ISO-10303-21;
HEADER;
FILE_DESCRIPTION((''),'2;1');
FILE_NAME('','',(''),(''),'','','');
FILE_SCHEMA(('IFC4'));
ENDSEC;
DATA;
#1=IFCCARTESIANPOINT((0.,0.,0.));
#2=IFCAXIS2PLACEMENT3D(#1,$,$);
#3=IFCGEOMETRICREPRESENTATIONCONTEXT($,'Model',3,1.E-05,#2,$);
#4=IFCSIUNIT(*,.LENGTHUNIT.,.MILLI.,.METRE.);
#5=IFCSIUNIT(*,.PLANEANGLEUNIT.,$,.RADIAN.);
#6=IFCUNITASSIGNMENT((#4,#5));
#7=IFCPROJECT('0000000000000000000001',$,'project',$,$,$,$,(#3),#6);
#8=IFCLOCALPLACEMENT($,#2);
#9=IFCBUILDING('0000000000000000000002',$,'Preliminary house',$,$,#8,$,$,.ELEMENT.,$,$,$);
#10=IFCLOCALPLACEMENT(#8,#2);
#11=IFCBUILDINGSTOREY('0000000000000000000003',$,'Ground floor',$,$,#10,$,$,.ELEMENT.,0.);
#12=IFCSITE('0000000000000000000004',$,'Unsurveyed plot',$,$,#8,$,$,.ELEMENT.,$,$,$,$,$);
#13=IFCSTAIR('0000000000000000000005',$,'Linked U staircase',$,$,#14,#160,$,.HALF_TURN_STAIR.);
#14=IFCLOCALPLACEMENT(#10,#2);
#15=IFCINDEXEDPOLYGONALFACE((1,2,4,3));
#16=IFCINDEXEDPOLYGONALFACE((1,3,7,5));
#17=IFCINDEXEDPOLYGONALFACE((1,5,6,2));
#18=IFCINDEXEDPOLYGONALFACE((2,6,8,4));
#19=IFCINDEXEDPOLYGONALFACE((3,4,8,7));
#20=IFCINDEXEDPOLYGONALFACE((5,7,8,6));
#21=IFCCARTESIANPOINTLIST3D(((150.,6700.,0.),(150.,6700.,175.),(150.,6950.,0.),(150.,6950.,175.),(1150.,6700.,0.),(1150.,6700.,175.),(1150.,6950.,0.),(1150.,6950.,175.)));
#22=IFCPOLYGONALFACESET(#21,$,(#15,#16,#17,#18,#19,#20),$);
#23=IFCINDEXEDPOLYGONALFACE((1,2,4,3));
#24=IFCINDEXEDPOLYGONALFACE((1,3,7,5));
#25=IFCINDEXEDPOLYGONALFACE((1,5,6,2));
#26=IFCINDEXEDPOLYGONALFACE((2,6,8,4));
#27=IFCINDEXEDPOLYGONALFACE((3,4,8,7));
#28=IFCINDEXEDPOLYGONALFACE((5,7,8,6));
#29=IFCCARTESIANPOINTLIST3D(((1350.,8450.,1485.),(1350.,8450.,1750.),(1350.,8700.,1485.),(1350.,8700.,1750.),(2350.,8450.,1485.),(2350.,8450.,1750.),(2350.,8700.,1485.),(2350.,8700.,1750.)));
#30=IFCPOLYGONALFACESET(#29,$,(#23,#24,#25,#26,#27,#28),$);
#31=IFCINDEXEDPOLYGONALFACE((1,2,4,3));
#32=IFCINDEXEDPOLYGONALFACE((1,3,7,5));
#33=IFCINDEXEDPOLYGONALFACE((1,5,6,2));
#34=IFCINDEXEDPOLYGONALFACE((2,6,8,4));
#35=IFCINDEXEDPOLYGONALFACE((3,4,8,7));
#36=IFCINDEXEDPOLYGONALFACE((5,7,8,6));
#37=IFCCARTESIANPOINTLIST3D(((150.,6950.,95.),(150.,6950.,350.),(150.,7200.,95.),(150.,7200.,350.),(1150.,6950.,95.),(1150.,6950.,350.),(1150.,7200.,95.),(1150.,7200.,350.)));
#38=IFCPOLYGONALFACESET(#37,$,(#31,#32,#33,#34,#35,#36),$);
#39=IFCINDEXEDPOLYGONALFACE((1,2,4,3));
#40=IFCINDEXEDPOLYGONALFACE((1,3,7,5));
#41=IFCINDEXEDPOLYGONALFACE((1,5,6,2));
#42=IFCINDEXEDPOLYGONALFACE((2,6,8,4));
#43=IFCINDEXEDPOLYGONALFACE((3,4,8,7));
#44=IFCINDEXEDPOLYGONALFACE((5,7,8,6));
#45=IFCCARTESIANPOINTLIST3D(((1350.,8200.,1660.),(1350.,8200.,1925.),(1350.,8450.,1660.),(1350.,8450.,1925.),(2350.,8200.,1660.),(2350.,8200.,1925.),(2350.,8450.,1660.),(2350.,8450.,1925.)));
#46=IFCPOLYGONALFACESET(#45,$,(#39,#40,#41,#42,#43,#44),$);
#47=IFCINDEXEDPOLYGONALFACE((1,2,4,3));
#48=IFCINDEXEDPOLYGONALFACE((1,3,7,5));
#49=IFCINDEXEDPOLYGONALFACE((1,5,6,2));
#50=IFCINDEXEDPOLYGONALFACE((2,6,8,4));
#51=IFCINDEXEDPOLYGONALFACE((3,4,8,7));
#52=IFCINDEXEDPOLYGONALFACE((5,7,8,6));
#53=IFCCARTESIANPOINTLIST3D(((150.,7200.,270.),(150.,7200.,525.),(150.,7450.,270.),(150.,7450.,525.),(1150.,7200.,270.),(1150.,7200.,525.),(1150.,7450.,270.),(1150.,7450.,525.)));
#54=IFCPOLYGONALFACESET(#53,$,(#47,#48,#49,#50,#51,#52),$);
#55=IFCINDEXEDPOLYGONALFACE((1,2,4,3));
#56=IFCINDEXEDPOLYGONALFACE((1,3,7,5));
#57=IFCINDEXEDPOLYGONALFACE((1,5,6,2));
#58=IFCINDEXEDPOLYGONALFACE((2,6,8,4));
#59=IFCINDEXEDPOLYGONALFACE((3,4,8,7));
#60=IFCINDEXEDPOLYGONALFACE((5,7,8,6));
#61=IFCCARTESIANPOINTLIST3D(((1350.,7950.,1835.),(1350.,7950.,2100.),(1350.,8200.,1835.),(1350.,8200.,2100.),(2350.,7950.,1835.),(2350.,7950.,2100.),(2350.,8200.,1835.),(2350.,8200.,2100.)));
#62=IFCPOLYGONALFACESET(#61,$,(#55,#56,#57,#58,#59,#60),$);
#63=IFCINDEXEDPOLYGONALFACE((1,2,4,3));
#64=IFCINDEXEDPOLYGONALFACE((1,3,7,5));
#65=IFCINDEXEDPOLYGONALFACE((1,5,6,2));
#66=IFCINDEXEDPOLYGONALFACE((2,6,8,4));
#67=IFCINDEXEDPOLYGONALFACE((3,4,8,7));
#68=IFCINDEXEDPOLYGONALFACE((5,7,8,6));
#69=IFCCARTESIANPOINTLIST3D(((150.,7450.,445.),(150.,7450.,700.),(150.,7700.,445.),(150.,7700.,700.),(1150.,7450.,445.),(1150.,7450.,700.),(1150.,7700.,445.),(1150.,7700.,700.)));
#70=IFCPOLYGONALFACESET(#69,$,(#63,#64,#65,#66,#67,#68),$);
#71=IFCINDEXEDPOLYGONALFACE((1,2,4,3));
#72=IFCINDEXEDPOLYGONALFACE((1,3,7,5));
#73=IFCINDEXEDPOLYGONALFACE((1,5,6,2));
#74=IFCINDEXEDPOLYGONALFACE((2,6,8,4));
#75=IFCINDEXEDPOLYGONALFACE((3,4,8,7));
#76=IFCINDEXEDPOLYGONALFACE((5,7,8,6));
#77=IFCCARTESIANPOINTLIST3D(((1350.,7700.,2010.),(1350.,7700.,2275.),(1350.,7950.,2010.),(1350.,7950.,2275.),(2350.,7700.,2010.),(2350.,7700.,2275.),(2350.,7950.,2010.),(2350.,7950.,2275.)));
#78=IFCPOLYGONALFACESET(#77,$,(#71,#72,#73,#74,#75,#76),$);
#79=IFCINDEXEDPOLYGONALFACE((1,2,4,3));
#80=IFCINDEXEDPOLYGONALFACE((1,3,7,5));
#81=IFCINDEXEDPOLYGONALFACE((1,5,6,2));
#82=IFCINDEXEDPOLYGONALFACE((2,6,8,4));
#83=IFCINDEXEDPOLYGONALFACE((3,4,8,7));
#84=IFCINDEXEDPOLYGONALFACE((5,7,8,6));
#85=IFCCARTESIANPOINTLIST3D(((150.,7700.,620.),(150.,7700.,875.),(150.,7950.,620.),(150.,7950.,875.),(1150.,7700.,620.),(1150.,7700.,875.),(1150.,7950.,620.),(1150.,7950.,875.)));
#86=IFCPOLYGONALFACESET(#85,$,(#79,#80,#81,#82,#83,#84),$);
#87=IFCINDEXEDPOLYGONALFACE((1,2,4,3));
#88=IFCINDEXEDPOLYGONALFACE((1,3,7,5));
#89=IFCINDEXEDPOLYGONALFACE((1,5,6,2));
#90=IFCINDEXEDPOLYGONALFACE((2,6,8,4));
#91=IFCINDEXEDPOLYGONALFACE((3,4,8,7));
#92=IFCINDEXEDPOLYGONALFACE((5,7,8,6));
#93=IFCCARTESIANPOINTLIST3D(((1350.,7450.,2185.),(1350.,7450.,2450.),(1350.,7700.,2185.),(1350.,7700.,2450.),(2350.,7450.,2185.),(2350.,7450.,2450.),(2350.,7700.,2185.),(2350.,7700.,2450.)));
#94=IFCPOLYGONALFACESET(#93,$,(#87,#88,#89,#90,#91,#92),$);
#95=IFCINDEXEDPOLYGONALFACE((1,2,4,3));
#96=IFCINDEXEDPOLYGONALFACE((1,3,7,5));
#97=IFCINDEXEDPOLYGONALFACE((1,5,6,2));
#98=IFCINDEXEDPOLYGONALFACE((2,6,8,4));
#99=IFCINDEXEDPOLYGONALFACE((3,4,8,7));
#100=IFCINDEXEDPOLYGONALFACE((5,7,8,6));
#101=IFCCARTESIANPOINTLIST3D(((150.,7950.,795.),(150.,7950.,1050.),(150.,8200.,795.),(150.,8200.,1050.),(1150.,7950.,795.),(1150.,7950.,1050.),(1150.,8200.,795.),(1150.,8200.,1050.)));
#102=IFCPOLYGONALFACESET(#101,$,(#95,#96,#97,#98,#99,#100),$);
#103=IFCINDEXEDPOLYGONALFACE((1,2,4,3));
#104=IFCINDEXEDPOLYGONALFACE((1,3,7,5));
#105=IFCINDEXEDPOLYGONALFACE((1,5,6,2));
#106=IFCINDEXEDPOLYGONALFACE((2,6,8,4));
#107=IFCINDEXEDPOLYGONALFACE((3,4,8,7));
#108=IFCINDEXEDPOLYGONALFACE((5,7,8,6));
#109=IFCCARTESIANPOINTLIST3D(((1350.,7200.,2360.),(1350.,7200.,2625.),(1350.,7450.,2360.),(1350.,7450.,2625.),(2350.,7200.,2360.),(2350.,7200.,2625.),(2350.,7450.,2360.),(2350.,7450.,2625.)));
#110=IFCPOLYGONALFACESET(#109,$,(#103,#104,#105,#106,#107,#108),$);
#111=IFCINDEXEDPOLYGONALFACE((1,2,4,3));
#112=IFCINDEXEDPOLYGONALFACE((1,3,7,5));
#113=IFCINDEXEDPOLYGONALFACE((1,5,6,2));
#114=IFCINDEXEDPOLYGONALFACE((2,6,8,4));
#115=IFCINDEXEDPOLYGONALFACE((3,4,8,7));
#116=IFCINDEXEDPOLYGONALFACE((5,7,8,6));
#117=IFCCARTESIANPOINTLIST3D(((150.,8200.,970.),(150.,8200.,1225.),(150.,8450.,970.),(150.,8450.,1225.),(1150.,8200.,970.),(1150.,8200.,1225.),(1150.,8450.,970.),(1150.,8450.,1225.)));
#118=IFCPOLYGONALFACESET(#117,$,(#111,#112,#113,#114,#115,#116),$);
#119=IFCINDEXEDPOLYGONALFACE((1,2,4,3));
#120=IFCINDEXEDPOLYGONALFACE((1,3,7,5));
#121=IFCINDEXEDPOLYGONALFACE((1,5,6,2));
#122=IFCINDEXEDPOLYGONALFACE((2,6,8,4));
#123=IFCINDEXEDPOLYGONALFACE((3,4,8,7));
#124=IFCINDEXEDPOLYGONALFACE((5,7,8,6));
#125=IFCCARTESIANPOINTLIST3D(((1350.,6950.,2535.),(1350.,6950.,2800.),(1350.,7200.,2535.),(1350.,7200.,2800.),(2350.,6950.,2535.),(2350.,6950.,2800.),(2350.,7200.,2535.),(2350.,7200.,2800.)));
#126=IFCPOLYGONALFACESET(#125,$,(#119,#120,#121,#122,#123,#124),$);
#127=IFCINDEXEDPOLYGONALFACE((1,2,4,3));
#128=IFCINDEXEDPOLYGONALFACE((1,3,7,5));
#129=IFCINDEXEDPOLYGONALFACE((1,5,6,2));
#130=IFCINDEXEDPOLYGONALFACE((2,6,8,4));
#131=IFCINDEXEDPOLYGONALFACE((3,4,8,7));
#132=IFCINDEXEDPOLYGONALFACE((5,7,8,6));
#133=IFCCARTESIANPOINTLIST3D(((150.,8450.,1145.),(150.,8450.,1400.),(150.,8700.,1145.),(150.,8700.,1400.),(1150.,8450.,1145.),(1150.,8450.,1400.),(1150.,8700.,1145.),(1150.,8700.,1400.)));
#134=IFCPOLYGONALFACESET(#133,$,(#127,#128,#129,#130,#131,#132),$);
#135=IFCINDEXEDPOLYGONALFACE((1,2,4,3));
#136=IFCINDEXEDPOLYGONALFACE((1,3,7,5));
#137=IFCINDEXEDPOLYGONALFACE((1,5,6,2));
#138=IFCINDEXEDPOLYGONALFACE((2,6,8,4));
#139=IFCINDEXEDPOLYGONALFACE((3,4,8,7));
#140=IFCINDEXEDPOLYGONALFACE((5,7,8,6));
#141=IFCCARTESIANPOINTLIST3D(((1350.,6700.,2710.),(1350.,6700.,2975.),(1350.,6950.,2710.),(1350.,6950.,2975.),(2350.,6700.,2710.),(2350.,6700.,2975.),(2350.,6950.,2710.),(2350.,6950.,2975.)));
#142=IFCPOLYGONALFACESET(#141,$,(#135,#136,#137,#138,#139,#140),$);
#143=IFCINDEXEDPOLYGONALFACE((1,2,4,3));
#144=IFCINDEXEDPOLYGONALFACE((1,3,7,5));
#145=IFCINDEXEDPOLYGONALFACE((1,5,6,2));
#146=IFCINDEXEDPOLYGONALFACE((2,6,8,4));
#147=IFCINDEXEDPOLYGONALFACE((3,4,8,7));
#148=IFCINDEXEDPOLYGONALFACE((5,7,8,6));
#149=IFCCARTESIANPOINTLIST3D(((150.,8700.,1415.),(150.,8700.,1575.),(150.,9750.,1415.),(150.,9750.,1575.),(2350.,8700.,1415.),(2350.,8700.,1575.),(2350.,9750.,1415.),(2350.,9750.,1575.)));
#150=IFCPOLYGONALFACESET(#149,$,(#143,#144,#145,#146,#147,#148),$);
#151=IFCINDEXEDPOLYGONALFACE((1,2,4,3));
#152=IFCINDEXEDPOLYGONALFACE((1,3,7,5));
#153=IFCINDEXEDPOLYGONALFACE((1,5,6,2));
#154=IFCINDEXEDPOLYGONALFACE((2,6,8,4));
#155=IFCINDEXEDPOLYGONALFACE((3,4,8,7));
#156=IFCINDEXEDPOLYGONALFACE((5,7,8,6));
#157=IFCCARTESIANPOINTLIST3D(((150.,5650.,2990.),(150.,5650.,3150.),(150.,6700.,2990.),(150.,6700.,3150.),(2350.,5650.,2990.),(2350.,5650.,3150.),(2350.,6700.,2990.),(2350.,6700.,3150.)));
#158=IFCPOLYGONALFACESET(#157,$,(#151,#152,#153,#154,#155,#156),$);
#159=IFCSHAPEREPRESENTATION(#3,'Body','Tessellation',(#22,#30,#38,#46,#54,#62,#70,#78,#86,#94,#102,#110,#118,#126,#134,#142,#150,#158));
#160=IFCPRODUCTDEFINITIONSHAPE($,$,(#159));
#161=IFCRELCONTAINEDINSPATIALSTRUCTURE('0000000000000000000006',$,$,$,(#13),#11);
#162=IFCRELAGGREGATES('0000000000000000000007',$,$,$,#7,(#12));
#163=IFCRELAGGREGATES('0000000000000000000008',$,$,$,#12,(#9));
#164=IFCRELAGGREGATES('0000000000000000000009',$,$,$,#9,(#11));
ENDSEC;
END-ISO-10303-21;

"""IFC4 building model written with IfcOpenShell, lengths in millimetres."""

from ifc_helpers import new_model, si_unit, frame, origin, place, context, project, spatial, polyline, outline, extrude, element, save


model = new_model("IFC4")

# Units and contexts
model_context = context("Model", 3, precision=1e-05, world=origin())
ifc_project = project(units=[si_unit("LENGTHUNIT", "METRE", prefix="MILLI"), si_unit("PLANEANGLEUNIT", "RADIAN")], contexts=[model_context])

# Site, building, storey
placement_1 = place(None, origin())
site = spatial("IfcSite", under=ifc_project, at=placement_1, Name="Unsurveyed plot", CompositionType="ELEMENT")
building = spatial("IfcBuilding", under=site, at=placement_1, Name="Preliminary house", CompositionType="ELEMENT")
placement_2 = place(placement_1, origin())
storey = spatial("IfcBuildingStorey", under=building, at=placement_2, Name="Ground floor", CompositionType="ELEMENT", Elevation=0.0)

# Stair
element("IfcStair", 1, at=placement_2, inside=storey, Name="Linked U staircase", PredefinedType="HALF_TURN_STAIR", context=model_context, shape_type="SweptSolid", body=[
    extrude(outline(polyline([(1150.0, 6700.0), (1150.0, 6950.0), (150.0, 6950.0), (150.0, 6700.0), (1150.0, 6700.0)])), origin(), (0.0, 0.0, 1.0), 175.0),
    extrude(outline(polyline([(2350.0, 8450.0), (2350.0, 8700.0), (1350.0, 8700.0), (1350.0, 8450.0), (2350.0, 8450.0)])), frame((0.0, 0.0, 1485.0)), (0.0, 0.0, 1.0), 265.0),
    extrude(outline(polyline([(1150.0, 6950.0), (1150.0, 7200.0), (150.0, 7200.0), (150.0, 6950.0), (1150.0, 6950.0)])), frame((0.0, 0.0, 95.0)), (0.0, 0.0, 1.0), 255.0),
    extrude(outline(polyline([(2350.0, 8200.0), (2350.0, 8450.0), (1350.0, 8450.0), (1350.0, 8200.0), (2350.0, 8200.0)])), frame((0.0, 0.0, 1660.0)), (0.0, 0.0, 1.0), 265.0),
    extrude(outline(polyline([(1150.0, 7200.0), (1150.0, 7450.0), (150.0, 7450.0), (150.0, 7200.0), (1150.0, 7200.0)])), frame((0.0, 0.0, 270.0)), (0.0, 0.0, 1.0), 255.0),
    extrude(outline(polyline([(2350.0, 7950.0), (2350.0, 8200.0), (1350.0, 8200.0), (1350.0, 7950.0), (2350.0, 7950.0)])), frame((0.0, 0.0, 1835.0)), (0.0, 0.0, 1.0), 265.0),
    extrude(outline(polyline([(1150.0, 7450.0), (1150.0, 7700.0), (150.0, 7700.0), (150.0, 7450.0), (1150.0, 7450.0)])), frame((0.0, 0.0, 445.0)), (0.0, 0.0, 1.0), 255.0),
    extrude(outline(polyline([(2350.0, 7700.0), (2350.0, 7950.0), (1350.0, 7950.0), (1350.0, 7700.0), (2350.0, 7700.0)])), frame((0.0, 0.0, 2010.0)), (0.0, 0.0, 1.0), 265.0),
    extrude(outline(polyline([(1150.0, 7700.0), (1150.0, 7950.0), (150.0, 7950.0), (150.0, 7700.0), (1150.0, 7700.0)])), frame((0.0, 0.0, 620.0)), (0.0, 0.0, 1.0), 255.0),
    extrude(outline(polyline([(2350.0, 7450.0), (2350.0, 7700.0), (1350.0, 7700.0), (1350.0, 7450.0), (2350.0, 7450.0)])), frame((0.0, 0.0, 2185.0)), (0.0, 0.0, 1.0), 265.0),
    extrude(outline(polyline([(1150.0, 7950.0), (1150.0, 8200.0), (150.0, 8200.0), (150.0, 7950.0), (1150.0, 7950.0)])), frame((0.0, 0.0, 795.0)), (0.0, 0.0, 1.0), 255.0),
    extrude(outline(polyline([(2350.0, 7200.0), (2350.0, 7450.0), (1350.0, 7450.0), (1350.0, 7200.0), (2350.0, 7200.0)])), frame((0.0, 0.0, 2360.0)), (0.0, 0.0, 1.0), 265.0),
    extrude(outline(polyline([(1150.0, 8200.0), (1150.0, 8450.0), (150.0, 8450.0), (150.0, 8200.0), (1150.0, 8200.0)])), frame((0.0, 0.0, 970.0)), (0.0, 0.0, 1.0), 255.0),
    extrude(outline(polyline([(2350.0, 6950.0), (2350.0, 7200.0), (1350.0, 7200.0), (1350.0, 6950.0), (2350.0, 6950.0)])), frame((0.0, 0.0, 2535.0)), (0.0, 0.0, 1.0), 265.0),
    extrude(outline(polyline([(1150.0, 8450.0), (1150.0, 8700.0), (150.0, 8700.0), (150.0, 8450.0), (1150.0, 8450.0)])), frame((0.0, 0.0, 1145.0)), (0.0, 0.0, 1.0), 255.0),
    extrude(outline(polyline([(2350.0, 6700.0), (2350.0, 6950.0), (1350.0, 6950.0), (1350.0, 6700.0), (2350.0, 6700.0)])), frame((0.0, 0.0, 2710.0)), (0.0, 0.0, 1.0), 265.0),
    extrude(outline(polyline([(2350.0, 8700.0), (2350.0, 9750.0), (150.0, 9750.0), (150.0, 8700.0), (2350.0, 8700.0)])), frame((0.0, 0.0, 1415.0)), (0.0, 0.0, 1.0), 160.0),
    extrude(outline(polyline([(2350.0, 5650.0), (2350.0, 6700.0), (150.0, 6700.0), (150.0, 5650.0), (2350.0, 5650.0)])), frame((0.0, 0.0, 2990.0)), (0.0, 0.0, 1.0), 160.0),
])

save(model, "model.ifc")
